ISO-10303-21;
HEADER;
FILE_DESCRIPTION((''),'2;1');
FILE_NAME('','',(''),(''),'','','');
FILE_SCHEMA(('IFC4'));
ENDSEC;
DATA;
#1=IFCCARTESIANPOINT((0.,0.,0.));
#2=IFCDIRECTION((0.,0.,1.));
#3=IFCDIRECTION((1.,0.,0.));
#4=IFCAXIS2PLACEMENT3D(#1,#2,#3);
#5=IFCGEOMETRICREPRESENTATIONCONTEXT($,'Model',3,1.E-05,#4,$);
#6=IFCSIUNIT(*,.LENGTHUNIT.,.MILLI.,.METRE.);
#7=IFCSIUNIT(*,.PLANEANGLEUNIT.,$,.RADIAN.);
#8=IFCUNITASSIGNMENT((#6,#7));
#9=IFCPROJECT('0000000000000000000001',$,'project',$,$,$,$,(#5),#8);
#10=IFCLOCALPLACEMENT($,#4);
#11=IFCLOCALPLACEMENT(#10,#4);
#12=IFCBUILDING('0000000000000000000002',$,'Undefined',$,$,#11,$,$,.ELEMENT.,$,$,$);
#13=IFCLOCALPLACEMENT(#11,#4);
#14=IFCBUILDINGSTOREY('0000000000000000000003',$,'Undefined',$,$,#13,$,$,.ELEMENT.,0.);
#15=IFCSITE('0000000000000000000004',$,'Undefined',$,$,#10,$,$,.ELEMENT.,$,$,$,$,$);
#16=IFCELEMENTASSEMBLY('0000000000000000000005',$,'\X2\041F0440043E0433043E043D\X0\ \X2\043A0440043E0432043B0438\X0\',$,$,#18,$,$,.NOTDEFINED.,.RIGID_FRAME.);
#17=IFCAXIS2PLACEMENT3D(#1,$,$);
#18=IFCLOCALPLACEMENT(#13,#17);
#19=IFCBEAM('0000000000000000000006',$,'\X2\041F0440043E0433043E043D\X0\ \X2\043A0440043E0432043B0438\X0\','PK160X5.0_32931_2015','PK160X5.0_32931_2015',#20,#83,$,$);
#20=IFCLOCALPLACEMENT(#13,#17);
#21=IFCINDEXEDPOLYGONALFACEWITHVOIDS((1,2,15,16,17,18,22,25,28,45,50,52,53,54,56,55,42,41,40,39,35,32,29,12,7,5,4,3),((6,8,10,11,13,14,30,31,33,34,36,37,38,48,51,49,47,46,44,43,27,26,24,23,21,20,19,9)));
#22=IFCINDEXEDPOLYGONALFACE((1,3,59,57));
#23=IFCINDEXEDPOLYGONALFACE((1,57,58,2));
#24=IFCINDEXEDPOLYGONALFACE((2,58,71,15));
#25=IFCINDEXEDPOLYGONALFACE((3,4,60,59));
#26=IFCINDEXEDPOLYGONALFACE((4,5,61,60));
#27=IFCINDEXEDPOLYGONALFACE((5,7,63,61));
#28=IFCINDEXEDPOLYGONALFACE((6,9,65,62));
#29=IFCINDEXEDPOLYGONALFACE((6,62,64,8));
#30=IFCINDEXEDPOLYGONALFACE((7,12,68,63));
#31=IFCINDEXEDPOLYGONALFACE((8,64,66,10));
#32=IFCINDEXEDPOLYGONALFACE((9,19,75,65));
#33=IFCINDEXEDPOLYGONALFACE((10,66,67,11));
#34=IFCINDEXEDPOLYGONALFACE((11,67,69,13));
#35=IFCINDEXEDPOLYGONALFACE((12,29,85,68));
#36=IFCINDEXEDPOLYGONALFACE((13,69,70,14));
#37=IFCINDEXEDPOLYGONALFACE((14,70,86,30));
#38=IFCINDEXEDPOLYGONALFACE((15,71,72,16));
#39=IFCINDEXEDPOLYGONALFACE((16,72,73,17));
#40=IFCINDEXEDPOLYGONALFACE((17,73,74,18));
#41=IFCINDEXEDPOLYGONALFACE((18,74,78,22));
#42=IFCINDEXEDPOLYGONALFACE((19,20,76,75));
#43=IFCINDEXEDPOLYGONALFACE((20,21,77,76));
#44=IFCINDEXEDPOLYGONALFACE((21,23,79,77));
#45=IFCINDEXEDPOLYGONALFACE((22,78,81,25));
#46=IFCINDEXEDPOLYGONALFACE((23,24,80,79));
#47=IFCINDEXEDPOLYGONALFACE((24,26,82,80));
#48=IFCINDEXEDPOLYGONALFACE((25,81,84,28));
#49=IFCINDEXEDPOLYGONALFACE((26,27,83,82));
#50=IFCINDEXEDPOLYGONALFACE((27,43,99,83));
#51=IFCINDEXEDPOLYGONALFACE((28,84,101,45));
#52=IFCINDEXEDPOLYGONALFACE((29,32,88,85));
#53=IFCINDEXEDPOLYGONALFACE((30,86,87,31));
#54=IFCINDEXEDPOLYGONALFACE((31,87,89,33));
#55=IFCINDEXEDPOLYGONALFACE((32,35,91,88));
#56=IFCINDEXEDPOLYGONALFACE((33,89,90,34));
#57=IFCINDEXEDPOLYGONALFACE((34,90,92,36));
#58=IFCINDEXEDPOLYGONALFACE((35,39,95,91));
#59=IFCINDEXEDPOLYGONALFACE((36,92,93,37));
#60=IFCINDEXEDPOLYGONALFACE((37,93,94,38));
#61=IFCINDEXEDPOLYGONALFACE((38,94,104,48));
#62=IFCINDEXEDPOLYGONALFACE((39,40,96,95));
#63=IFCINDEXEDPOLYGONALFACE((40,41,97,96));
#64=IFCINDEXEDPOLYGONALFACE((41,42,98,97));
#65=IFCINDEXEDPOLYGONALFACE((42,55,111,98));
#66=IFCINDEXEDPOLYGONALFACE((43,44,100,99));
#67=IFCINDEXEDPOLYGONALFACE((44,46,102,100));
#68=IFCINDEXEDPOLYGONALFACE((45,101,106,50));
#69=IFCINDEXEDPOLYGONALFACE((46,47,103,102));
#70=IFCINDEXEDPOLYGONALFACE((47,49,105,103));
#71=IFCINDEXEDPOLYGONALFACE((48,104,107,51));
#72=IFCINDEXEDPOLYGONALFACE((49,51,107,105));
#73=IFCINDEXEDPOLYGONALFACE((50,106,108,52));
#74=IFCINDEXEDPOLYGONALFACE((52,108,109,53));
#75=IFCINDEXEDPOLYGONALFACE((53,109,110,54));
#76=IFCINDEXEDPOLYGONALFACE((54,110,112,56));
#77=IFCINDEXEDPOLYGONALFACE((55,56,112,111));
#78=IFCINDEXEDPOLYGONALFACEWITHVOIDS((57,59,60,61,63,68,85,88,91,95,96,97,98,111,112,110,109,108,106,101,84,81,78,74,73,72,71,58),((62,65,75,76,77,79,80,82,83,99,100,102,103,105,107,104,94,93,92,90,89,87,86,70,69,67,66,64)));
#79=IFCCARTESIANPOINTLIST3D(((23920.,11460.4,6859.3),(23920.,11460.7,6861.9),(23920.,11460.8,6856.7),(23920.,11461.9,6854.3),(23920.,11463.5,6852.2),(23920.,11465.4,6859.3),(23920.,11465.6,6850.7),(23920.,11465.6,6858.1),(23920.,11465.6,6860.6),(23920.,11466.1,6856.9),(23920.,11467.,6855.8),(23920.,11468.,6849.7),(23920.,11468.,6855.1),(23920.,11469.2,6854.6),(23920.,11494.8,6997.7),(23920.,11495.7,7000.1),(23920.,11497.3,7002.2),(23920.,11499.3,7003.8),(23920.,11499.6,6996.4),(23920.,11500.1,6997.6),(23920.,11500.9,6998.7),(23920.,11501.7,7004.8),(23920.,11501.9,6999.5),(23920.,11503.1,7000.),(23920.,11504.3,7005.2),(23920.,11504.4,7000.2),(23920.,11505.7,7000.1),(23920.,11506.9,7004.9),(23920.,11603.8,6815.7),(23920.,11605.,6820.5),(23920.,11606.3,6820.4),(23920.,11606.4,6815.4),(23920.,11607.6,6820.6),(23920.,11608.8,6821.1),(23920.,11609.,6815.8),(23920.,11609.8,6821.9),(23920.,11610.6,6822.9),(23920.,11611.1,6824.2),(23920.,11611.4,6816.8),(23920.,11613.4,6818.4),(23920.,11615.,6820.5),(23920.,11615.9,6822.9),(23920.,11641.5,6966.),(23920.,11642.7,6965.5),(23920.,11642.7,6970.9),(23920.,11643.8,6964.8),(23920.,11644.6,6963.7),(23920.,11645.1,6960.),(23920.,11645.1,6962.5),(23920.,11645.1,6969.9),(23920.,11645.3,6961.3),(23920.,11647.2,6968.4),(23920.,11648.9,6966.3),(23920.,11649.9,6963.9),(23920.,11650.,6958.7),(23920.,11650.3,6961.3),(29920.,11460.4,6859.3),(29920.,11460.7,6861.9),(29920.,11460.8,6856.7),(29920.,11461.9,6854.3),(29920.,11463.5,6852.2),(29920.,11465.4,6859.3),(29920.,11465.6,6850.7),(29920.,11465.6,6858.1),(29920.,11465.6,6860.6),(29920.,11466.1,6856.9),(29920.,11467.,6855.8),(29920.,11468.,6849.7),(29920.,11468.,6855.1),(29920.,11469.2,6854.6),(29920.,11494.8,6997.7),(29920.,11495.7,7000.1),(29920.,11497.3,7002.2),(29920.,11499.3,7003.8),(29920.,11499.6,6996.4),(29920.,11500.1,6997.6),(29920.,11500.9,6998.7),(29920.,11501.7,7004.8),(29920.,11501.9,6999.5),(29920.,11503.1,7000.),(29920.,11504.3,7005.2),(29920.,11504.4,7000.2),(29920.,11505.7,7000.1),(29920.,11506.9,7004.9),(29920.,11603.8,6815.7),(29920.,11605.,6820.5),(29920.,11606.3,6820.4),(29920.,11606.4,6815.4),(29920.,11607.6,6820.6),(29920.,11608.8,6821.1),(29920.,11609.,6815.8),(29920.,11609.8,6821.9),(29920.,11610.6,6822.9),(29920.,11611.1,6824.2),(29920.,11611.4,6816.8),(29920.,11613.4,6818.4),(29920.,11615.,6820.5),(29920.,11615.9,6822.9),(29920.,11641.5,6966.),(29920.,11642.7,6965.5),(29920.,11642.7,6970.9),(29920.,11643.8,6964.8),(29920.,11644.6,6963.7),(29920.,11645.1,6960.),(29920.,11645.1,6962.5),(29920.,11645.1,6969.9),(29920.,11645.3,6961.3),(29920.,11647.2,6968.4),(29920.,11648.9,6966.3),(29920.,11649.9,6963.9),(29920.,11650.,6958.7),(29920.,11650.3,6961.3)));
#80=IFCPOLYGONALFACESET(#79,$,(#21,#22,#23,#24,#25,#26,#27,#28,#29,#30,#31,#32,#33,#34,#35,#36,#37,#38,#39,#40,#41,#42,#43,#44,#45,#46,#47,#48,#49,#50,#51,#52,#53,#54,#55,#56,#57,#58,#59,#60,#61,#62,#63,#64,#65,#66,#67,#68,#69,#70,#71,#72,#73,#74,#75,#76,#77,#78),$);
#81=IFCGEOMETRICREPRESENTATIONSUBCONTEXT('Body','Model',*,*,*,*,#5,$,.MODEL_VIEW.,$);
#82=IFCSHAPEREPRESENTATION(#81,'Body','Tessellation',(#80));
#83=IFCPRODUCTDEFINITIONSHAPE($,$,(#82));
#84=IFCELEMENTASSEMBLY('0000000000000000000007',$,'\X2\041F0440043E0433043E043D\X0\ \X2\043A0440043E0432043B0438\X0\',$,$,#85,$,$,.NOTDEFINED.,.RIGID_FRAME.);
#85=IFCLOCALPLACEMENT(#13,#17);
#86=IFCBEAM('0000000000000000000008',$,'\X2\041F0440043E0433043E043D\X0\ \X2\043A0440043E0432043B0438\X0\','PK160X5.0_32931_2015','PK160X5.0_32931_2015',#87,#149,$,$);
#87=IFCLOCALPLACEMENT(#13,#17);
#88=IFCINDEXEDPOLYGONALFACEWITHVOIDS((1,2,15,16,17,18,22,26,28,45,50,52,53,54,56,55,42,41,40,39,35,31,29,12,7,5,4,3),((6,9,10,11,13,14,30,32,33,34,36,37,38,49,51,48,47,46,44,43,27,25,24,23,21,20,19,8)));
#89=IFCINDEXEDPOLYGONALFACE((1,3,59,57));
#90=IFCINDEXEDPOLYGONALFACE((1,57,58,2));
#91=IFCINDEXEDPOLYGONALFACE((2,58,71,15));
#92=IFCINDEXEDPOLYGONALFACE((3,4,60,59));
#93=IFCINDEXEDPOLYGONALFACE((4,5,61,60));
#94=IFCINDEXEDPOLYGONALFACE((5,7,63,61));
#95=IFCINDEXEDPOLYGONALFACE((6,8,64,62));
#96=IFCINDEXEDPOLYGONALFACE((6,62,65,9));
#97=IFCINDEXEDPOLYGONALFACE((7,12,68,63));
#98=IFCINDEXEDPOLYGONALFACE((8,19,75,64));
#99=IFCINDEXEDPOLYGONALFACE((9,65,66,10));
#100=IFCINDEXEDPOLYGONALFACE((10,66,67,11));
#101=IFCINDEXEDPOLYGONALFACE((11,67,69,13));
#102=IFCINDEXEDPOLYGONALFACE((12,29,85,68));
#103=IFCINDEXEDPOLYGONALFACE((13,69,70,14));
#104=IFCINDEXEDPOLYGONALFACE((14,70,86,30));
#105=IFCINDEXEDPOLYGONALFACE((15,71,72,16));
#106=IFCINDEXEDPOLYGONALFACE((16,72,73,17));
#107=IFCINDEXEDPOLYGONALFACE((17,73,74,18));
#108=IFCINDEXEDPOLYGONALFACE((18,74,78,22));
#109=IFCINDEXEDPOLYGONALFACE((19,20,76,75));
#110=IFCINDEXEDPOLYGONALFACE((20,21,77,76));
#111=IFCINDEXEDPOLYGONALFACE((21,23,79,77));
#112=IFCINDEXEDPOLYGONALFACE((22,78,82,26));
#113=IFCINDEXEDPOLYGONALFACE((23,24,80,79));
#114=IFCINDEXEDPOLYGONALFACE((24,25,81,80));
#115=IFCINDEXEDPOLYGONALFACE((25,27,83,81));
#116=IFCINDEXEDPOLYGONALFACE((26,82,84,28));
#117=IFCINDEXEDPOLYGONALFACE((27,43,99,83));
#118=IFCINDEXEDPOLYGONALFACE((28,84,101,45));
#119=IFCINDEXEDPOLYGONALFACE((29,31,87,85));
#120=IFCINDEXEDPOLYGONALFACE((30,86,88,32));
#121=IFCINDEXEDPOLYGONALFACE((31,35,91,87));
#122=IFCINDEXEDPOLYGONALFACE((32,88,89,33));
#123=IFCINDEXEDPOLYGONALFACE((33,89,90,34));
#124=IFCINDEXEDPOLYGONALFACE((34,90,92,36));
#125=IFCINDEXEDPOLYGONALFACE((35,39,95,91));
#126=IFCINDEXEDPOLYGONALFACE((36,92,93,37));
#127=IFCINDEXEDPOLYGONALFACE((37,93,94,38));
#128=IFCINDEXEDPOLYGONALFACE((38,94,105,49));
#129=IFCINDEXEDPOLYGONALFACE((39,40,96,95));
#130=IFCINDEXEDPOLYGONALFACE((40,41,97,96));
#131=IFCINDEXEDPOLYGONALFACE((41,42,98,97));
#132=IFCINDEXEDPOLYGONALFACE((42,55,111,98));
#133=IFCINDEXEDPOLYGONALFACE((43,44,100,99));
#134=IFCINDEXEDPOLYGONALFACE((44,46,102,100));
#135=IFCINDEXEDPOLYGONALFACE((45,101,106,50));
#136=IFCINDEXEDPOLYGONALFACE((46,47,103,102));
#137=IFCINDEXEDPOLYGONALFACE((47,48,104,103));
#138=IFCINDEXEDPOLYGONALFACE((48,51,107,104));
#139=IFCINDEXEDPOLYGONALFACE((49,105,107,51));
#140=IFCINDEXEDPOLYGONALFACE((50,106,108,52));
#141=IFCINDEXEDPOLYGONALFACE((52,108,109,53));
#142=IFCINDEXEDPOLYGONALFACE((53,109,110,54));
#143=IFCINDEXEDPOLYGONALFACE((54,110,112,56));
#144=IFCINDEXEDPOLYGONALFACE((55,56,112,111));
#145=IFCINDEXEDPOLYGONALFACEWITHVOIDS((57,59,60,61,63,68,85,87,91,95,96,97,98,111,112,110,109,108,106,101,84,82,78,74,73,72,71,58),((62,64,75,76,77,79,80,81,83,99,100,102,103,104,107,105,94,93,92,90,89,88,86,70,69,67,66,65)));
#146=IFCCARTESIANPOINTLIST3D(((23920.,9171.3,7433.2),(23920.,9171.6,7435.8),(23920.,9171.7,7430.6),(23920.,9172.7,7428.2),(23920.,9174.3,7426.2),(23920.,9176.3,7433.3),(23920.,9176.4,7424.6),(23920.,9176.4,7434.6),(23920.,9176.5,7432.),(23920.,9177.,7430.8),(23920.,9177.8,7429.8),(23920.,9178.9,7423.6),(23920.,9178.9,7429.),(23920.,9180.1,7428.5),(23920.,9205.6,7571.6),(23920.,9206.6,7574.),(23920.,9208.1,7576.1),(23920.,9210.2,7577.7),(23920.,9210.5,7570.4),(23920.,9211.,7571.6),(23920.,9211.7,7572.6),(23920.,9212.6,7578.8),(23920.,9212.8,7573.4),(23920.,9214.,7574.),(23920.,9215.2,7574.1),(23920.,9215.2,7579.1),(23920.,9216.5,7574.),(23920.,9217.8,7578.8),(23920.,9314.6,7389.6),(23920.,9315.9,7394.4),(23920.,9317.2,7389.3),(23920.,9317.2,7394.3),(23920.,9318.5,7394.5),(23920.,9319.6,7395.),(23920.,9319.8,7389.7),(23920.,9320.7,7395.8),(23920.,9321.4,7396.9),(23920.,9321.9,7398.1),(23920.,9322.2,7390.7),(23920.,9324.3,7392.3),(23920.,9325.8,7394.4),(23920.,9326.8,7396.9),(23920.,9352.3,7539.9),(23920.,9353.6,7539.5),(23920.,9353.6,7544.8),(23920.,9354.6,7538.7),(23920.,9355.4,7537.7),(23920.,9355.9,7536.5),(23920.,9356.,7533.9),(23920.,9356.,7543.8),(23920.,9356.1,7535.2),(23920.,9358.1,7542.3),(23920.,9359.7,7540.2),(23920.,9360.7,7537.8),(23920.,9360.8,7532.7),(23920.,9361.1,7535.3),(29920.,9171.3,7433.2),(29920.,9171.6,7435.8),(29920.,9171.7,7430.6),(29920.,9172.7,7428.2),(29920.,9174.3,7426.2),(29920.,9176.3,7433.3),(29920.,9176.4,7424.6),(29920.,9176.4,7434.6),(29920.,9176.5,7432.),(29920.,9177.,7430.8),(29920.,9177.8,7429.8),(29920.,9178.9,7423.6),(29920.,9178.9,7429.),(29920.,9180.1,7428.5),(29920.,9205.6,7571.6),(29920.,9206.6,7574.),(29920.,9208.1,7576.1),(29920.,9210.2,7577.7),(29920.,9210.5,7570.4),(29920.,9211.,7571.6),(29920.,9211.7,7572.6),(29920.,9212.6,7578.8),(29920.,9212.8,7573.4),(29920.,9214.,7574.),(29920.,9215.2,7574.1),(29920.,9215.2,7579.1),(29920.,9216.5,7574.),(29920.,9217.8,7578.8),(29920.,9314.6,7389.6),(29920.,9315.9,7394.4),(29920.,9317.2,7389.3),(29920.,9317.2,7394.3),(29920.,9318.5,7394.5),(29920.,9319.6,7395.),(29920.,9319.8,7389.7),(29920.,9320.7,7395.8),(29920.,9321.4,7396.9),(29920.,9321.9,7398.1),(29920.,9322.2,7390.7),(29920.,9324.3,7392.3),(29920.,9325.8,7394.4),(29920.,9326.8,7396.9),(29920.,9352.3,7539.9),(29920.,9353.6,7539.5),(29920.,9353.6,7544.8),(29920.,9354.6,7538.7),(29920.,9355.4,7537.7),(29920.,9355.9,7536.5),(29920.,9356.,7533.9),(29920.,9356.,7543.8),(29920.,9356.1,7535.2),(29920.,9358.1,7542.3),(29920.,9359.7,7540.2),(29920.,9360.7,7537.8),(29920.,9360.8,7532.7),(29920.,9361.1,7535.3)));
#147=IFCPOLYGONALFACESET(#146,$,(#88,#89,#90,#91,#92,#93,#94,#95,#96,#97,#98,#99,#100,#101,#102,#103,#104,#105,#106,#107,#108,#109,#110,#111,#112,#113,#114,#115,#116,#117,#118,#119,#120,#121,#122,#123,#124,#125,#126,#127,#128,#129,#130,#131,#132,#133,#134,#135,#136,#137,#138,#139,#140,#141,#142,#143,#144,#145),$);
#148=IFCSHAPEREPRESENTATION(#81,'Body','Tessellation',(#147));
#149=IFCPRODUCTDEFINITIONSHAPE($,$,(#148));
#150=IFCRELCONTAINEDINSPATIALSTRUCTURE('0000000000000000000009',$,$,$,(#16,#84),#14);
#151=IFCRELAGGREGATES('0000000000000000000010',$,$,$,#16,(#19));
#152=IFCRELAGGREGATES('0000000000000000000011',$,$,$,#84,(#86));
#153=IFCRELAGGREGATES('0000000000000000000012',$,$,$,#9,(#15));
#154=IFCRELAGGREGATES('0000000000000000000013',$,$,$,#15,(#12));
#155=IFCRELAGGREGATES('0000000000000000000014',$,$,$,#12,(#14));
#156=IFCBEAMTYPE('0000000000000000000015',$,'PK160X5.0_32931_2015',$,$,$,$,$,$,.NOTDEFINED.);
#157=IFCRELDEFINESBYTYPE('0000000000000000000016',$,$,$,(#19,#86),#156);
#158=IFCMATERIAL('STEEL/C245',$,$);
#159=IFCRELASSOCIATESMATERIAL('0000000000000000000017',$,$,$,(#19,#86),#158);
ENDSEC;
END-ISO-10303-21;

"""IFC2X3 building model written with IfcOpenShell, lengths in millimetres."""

from ifc_helpers import new_model, si_unit, frame, origin_with_axes, origin_2d_with_axis, place, context, subcontext, project, spatial, hollow_rectangle, extrude, material, type_object, element, aggregate, save


model = new_model("IFC2X3")

# Units and contexts
model_context = context("Model", 3, precision=1e-05, world=origin_with_axes())
body_context = subcontext(model_context, "Body", "Model", "MODEL_VIEW")
ifc_project = project(units=[si_unit("LENGTHUNIT", "METRE", prefix="MILLI"), si_unit("PLANEANGLEUNIT", "RADIAN")], contexts=[model_context])

# Site, building, storey
site_placement = place(None, origin_with_axes())
site = spatial("IfcSite", under=ifc_project, at=site_placement, Name="Undefined", CompositionType="ELEMENT")
building_placement = place(site_placement, origin_with_axes())
building = spatial("IfcBuilding", under=site, at=building_placement, Name="Undefined", CompositionType="ELEMENT")
storey_placement = place(building_placement, origin_with_axes())
storey = spatial("IfcBuildingStorey", under=building, at=storey_placement, Name="Undefined", CompositionType="ELEMENT", Elevation=0.0)

# Shared definitions
ifc_material = material(Name="STEEL/C245")

# Element assemblies, beams
assembly_1_placement = place(storey_placement, origin_with_axes())
assembly_1 = element("IfcElementAssembly", 1, at=assembly_1_placement, inside=storey, Name="Прогон кровли", AssemblyPlace="NOTDEFINED", PredefinedType="RIGID_FRAME")
beam_type_1 = type_object("IfcBeamType", Name="PK160X5.0_32931_2015", PredefinedType="NOTDEFINED")
beam_1_placement = place(assembly_1_placement, frame((23920.0, 11555.4, 6910.3), z_axis=(0.0, 0.243188, 0.969979), x_axis=(1.0, 0.0, 0.0)))
beam_1 = element("IfcBeam", 2, at=beam_1_placement, type_object=beam_type_1, material=ifc_material, Name="Прогон кровли", Description="PK160X5.0_32931_2015", ObjectType="PK160X5.0_32931_2015", context=body_context, shape_type="SweptSolid", body=[
    extrude(hollow_rectangle(XDim=160.0, YDim=160.0, WallThickness=5.0, InnerFilletRadius=5.0, OuterFilletRadius=10.0, at=origin_2d_with_axis()), frame((6000.0, 0.0, 0.0), z_axis=(-1.0, 0.0, 0.0), x_axis=(0.0, -1.0, 0.0)), (0.0, 0.0, 1.0), 6000.0),
])
aggregate(assembly_1, [beam_1])
assembly_2_placement = place(storey_placement, origin_with_axes())
assembly_2 = element("IfcElementAssembly", 3, at=assembly_2_placement, inside=storey, Name="Прогон кровли", AssemblyPlace="NOTDEFINED", PredefinedType="RIGID_FRAME")
beam_2_placement = place(assembly_2_placement, frame((23920.0, 9266.2, 7484.2), z_axis=(0.0, 0.243188, 0.969979), x_axis=(1.0, 0.0, 0.0)))
beam_2 = element("IfcBeam", 4, at=beam_2_placement, type_object=beam_type_1, material=ifc_material, Name="Прогон кровли", Description="PK160X5.0_32931_2015", ObjectType="PK160X5.0_32931_2015", context=body_context, shape_type="SweptSolid", body=[
    extrude(hollow_rectangle(XDim=160.0, YDim=160.0, WallThickness=5.0, InnerFilletRadius=5.0, OuterFilletRadius=10.0, at=origin_2d_with_axis()), frame((6000.0, 0.0, 0.0), z_axis=(-1.0, 0.0, 0.0), x_axis=(0.0, -1.0, 0.0)), (0.0, 0.0, 1.0), 6000.0),
])
aggregate(assembly_2, [beam_2])

save(model, "model.ifc")
